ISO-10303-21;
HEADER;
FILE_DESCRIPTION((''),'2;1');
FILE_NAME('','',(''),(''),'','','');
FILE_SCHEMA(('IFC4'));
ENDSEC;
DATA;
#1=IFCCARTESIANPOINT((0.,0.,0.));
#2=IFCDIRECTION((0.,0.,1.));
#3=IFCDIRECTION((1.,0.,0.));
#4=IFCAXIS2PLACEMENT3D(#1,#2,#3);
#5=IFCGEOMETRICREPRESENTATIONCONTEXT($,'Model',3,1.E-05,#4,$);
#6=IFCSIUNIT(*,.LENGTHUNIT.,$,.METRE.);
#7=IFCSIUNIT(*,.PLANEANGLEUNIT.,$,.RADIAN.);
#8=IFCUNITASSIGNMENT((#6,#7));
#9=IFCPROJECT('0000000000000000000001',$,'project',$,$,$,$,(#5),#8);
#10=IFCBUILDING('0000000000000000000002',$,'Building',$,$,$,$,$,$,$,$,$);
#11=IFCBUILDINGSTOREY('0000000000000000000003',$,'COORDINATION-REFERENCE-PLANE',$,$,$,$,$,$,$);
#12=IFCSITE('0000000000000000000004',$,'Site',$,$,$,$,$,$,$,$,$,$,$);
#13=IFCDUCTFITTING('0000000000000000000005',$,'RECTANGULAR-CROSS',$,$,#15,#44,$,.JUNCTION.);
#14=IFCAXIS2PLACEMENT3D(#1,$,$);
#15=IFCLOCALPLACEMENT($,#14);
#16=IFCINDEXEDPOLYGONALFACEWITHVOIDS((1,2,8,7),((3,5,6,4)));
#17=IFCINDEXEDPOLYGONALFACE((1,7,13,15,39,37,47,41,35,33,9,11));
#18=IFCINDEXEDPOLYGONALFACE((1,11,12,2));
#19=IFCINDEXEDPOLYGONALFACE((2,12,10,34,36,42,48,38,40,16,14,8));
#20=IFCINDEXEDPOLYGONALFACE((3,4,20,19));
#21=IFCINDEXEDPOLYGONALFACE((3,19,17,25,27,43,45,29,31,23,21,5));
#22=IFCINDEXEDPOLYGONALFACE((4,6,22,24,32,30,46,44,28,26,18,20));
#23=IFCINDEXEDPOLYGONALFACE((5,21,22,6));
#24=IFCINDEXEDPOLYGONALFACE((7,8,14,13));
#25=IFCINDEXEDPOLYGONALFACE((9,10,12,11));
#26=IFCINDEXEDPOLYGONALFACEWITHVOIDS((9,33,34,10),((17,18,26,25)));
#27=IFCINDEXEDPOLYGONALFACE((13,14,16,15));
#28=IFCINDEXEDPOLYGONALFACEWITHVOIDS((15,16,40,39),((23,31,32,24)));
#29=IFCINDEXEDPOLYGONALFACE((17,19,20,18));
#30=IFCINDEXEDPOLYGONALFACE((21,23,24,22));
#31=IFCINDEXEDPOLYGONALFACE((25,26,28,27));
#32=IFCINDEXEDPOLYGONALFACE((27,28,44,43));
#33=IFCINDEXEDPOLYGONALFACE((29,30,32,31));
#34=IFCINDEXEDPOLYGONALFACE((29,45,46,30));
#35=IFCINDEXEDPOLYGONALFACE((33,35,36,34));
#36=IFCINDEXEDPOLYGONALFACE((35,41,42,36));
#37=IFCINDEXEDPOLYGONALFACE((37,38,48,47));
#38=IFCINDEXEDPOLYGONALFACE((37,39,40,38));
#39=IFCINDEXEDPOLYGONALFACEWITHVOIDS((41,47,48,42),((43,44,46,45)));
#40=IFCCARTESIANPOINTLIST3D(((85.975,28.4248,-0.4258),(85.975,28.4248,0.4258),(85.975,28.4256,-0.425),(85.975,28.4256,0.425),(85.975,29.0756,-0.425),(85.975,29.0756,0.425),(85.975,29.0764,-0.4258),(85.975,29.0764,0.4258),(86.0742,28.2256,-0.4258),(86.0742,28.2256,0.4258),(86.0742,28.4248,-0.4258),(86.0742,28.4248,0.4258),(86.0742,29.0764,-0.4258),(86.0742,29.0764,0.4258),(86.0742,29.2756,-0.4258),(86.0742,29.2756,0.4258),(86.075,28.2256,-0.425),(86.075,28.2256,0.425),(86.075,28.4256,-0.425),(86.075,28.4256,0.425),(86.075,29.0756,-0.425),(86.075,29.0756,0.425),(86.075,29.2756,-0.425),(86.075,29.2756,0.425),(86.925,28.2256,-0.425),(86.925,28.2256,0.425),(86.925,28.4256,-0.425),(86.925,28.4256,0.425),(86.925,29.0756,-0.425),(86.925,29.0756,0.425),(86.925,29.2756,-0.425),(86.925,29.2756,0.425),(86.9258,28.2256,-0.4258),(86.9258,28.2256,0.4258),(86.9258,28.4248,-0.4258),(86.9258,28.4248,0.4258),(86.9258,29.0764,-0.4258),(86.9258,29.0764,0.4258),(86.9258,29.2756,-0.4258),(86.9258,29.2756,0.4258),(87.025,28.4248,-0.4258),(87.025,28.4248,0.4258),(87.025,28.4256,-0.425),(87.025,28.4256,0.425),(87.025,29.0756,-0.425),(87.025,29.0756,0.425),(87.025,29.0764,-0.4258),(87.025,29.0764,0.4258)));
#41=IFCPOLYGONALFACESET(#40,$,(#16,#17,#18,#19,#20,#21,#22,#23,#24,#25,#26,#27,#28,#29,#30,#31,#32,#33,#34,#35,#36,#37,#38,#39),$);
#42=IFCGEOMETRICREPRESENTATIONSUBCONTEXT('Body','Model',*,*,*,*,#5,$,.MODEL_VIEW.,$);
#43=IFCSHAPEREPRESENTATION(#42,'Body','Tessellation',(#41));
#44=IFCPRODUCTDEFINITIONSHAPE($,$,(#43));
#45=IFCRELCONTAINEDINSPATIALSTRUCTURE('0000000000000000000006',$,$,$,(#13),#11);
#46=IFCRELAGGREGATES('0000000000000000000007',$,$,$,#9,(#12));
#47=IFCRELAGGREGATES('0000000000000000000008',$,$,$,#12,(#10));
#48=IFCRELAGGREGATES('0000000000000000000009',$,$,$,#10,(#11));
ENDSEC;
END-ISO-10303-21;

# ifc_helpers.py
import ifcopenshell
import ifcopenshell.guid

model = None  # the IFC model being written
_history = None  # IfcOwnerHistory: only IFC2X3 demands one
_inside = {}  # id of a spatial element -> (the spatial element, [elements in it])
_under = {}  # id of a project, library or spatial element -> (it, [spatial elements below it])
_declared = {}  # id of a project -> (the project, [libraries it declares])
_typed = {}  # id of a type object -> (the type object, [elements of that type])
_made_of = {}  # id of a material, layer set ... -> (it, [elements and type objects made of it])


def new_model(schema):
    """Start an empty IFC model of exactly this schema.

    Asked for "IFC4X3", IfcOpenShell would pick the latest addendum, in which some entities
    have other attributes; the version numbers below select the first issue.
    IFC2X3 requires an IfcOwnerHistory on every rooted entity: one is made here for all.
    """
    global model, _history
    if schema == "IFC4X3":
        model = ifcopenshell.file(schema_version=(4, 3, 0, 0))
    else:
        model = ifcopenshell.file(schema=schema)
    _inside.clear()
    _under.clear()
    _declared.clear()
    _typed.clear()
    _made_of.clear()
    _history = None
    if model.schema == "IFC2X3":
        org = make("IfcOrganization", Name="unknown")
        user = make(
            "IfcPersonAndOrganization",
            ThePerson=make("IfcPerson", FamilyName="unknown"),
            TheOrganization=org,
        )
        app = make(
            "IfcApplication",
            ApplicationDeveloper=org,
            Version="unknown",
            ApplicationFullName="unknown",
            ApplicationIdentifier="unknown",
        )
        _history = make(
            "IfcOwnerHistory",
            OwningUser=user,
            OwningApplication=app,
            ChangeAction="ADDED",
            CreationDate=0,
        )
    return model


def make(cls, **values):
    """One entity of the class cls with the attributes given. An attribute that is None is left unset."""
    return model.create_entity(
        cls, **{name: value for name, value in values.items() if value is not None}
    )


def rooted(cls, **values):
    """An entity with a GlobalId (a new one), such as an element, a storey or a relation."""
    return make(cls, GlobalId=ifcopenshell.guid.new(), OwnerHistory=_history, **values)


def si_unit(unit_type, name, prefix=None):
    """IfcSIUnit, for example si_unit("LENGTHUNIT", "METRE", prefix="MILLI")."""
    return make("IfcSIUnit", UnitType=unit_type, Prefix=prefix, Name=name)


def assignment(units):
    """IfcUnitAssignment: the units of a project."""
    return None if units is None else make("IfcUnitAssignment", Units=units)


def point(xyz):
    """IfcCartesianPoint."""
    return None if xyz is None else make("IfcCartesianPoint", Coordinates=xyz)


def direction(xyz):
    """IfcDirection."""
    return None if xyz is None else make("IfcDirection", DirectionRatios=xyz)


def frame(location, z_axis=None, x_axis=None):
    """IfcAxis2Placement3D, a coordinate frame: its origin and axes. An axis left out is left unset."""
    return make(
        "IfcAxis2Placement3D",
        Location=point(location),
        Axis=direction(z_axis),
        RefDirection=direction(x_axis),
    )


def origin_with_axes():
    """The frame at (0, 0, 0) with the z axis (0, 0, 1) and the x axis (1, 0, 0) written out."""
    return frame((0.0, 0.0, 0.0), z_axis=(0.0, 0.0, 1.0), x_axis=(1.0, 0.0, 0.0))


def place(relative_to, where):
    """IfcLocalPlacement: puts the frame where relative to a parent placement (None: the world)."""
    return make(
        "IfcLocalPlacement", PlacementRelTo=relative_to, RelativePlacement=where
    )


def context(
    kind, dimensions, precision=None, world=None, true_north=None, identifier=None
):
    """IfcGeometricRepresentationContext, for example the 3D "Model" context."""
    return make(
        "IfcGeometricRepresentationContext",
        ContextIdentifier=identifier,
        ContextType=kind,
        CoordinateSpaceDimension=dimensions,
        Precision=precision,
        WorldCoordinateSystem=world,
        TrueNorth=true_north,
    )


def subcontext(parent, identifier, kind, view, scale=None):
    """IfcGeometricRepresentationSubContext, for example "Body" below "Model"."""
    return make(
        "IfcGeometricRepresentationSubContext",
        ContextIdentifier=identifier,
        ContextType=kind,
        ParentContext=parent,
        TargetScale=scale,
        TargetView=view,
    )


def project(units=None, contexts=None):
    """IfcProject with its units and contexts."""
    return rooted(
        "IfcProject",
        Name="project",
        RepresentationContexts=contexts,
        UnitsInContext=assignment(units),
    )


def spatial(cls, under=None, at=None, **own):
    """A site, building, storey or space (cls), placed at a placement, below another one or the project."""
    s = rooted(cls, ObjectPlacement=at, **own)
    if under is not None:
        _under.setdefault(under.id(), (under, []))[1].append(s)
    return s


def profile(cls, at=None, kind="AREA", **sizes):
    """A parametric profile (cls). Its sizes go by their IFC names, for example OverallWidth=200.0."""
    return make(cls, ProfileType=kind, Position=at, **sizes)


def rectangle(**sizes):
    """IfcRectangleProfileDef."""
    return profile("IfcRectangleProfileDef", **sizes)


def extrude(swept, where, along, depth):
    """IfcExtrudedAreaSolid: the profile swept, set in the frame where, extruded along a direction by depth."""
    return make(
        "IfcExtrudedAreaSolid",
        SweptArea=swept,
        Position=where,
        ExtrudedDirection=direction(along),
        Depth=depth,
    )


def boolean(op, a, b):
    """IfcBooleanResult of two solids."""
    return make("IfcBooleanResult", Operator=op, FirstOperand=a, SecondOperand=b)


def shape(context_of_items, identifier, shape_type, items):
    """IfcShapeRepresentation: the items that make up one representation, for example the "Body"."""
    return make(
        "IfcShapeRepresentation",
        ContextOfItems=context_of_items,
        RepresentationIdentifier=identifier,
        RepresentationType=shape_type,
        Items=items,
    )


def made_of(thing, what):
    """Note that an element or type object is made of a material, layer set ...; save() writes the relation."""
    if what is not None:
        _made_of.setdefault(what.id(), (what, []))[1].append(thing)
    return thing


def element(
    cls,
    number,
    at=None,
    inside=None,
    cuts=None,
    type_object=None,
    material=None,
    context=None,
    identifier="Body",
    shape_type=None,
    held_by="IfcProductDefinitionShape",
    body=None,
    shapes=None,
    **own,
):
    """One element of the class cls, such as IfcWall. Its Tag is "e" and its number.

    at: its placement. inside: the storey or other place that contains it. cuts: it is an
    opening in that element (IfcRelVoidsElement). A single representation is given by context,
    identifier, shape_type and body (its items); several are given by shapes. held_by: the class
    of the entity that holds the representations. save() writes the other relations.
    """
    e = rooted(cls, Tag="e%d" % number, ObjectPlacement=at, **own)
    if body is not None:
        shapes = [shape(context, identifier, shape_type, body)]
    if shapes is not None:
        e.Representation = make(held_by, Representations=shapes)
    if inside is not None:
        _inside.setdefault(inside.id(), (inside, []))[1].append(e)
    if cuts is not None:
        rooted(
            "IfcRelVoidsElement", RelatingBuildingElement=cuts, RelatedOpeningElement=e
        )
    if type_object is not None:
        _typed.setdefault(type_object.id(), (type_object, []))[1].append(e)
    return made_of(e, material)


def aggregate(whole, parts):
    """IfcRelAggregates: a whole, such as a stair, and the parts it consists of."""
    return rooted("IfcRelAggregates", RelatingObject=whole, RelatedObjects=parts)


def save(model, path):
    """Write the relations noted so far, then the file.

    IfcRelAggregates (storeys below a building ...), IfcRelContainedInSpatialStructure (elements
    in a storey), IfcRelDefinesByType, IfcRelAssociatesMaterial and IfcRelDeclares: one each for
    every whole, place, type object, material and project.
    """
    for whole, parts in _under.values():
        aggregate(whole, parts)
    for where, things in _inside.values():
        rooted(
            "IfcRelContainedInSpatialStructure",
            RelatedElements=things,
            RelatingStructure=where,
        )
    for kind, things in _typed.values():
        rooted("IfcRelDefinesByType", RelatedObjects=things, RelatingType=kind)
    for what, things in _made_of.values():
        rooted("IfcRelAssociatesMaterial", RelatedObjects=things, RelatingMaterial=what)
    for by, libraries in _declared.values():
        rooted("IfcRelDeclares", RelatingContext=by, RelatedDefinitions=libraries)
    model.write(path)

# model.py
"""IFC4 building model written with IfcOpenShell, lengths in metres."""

from ifc_helpers import new_model, si_unit, frame, origin_with_axes, place, context, subcontext, project, spatial, rectangle, extrude, boolean, element, save


model = new_model("IFC4")

# Units and contexts
model_context = context("Model", 3, precision=1e-05, world=origin_with_axes())
body_context = subcontext(model_context, "Body", "Model", "MODEL_VIEW")
ifc_project = project(units=[si_unit("LENGTHUNIT", "METRE"), si_unit("PLANEANGLEUNIT", "RADIAN")], contexts=[model_context])

# Site, building, storey
site = spatial("IfcSite", under=ifc_project, Name="Site")
building = spatial("IfcBuilding", under=site, Name="Building")
storey = spatial("IfcBuildingStorey", under=building, Name="COORDINATION-REFERENCE-PLANE")

# Duct fitting
duct_fitting_1_placement = place(None, frame((86.5, 28.7506, 0.0), z_axis=(0.0, -1.0, 0.0), x_axis=(1.0, 0.0, 0.0)))
solid_1 = boolean("UNION", extrude(rectangle(XDim=0.85, YDim=0.85), frame((0.0, 0.0, -0.525), z_axis=(0.0, 0.0, 1.0), x_axis=(1.0, 0.0, 0.0)), (0.0, 0.0, 1.0), 1.05), extrude(rectangle(XDim=0.65, YDim=0.85), frame((-0.525, 0.0, 0.0), z_axis=(1.0, 0.0, 0.0), x_axis=(0.0, 0.0, -1.0)), (0.0, 0.0, 1.0), 1.05))
element("IfcDuctFitting", 1, at=duct_fitting_1_placement, inside=storey, Name="RECTANGULAR-CROSS", PredefinedType="JUNCTION", context=body_context, shape_type="CSG", body=[
    boolean("DIFFERENCE", boolean("UNION", extrude(rectangle(XDim=0.8516, YDim=0.8516), frame((0.0, 0.0, -0.525), z_axis=(0.0, 0.0, 1.0), x_axis=(1.0, 0.0, 0.0)), (0.0, 0.0, 1.0), 1.05), extrude(rectangle(XDim=0.6516, YDim=0.8516), frame((-0.525, 0.0, 0.0), z_axis=(1.0, 0.0, 0.0), x_axis=(0.0, 0.0, -1.0)), (0.0, 0.0, 1.0), 1.05)), solid_1),
])

save(model, "model.ifc")
